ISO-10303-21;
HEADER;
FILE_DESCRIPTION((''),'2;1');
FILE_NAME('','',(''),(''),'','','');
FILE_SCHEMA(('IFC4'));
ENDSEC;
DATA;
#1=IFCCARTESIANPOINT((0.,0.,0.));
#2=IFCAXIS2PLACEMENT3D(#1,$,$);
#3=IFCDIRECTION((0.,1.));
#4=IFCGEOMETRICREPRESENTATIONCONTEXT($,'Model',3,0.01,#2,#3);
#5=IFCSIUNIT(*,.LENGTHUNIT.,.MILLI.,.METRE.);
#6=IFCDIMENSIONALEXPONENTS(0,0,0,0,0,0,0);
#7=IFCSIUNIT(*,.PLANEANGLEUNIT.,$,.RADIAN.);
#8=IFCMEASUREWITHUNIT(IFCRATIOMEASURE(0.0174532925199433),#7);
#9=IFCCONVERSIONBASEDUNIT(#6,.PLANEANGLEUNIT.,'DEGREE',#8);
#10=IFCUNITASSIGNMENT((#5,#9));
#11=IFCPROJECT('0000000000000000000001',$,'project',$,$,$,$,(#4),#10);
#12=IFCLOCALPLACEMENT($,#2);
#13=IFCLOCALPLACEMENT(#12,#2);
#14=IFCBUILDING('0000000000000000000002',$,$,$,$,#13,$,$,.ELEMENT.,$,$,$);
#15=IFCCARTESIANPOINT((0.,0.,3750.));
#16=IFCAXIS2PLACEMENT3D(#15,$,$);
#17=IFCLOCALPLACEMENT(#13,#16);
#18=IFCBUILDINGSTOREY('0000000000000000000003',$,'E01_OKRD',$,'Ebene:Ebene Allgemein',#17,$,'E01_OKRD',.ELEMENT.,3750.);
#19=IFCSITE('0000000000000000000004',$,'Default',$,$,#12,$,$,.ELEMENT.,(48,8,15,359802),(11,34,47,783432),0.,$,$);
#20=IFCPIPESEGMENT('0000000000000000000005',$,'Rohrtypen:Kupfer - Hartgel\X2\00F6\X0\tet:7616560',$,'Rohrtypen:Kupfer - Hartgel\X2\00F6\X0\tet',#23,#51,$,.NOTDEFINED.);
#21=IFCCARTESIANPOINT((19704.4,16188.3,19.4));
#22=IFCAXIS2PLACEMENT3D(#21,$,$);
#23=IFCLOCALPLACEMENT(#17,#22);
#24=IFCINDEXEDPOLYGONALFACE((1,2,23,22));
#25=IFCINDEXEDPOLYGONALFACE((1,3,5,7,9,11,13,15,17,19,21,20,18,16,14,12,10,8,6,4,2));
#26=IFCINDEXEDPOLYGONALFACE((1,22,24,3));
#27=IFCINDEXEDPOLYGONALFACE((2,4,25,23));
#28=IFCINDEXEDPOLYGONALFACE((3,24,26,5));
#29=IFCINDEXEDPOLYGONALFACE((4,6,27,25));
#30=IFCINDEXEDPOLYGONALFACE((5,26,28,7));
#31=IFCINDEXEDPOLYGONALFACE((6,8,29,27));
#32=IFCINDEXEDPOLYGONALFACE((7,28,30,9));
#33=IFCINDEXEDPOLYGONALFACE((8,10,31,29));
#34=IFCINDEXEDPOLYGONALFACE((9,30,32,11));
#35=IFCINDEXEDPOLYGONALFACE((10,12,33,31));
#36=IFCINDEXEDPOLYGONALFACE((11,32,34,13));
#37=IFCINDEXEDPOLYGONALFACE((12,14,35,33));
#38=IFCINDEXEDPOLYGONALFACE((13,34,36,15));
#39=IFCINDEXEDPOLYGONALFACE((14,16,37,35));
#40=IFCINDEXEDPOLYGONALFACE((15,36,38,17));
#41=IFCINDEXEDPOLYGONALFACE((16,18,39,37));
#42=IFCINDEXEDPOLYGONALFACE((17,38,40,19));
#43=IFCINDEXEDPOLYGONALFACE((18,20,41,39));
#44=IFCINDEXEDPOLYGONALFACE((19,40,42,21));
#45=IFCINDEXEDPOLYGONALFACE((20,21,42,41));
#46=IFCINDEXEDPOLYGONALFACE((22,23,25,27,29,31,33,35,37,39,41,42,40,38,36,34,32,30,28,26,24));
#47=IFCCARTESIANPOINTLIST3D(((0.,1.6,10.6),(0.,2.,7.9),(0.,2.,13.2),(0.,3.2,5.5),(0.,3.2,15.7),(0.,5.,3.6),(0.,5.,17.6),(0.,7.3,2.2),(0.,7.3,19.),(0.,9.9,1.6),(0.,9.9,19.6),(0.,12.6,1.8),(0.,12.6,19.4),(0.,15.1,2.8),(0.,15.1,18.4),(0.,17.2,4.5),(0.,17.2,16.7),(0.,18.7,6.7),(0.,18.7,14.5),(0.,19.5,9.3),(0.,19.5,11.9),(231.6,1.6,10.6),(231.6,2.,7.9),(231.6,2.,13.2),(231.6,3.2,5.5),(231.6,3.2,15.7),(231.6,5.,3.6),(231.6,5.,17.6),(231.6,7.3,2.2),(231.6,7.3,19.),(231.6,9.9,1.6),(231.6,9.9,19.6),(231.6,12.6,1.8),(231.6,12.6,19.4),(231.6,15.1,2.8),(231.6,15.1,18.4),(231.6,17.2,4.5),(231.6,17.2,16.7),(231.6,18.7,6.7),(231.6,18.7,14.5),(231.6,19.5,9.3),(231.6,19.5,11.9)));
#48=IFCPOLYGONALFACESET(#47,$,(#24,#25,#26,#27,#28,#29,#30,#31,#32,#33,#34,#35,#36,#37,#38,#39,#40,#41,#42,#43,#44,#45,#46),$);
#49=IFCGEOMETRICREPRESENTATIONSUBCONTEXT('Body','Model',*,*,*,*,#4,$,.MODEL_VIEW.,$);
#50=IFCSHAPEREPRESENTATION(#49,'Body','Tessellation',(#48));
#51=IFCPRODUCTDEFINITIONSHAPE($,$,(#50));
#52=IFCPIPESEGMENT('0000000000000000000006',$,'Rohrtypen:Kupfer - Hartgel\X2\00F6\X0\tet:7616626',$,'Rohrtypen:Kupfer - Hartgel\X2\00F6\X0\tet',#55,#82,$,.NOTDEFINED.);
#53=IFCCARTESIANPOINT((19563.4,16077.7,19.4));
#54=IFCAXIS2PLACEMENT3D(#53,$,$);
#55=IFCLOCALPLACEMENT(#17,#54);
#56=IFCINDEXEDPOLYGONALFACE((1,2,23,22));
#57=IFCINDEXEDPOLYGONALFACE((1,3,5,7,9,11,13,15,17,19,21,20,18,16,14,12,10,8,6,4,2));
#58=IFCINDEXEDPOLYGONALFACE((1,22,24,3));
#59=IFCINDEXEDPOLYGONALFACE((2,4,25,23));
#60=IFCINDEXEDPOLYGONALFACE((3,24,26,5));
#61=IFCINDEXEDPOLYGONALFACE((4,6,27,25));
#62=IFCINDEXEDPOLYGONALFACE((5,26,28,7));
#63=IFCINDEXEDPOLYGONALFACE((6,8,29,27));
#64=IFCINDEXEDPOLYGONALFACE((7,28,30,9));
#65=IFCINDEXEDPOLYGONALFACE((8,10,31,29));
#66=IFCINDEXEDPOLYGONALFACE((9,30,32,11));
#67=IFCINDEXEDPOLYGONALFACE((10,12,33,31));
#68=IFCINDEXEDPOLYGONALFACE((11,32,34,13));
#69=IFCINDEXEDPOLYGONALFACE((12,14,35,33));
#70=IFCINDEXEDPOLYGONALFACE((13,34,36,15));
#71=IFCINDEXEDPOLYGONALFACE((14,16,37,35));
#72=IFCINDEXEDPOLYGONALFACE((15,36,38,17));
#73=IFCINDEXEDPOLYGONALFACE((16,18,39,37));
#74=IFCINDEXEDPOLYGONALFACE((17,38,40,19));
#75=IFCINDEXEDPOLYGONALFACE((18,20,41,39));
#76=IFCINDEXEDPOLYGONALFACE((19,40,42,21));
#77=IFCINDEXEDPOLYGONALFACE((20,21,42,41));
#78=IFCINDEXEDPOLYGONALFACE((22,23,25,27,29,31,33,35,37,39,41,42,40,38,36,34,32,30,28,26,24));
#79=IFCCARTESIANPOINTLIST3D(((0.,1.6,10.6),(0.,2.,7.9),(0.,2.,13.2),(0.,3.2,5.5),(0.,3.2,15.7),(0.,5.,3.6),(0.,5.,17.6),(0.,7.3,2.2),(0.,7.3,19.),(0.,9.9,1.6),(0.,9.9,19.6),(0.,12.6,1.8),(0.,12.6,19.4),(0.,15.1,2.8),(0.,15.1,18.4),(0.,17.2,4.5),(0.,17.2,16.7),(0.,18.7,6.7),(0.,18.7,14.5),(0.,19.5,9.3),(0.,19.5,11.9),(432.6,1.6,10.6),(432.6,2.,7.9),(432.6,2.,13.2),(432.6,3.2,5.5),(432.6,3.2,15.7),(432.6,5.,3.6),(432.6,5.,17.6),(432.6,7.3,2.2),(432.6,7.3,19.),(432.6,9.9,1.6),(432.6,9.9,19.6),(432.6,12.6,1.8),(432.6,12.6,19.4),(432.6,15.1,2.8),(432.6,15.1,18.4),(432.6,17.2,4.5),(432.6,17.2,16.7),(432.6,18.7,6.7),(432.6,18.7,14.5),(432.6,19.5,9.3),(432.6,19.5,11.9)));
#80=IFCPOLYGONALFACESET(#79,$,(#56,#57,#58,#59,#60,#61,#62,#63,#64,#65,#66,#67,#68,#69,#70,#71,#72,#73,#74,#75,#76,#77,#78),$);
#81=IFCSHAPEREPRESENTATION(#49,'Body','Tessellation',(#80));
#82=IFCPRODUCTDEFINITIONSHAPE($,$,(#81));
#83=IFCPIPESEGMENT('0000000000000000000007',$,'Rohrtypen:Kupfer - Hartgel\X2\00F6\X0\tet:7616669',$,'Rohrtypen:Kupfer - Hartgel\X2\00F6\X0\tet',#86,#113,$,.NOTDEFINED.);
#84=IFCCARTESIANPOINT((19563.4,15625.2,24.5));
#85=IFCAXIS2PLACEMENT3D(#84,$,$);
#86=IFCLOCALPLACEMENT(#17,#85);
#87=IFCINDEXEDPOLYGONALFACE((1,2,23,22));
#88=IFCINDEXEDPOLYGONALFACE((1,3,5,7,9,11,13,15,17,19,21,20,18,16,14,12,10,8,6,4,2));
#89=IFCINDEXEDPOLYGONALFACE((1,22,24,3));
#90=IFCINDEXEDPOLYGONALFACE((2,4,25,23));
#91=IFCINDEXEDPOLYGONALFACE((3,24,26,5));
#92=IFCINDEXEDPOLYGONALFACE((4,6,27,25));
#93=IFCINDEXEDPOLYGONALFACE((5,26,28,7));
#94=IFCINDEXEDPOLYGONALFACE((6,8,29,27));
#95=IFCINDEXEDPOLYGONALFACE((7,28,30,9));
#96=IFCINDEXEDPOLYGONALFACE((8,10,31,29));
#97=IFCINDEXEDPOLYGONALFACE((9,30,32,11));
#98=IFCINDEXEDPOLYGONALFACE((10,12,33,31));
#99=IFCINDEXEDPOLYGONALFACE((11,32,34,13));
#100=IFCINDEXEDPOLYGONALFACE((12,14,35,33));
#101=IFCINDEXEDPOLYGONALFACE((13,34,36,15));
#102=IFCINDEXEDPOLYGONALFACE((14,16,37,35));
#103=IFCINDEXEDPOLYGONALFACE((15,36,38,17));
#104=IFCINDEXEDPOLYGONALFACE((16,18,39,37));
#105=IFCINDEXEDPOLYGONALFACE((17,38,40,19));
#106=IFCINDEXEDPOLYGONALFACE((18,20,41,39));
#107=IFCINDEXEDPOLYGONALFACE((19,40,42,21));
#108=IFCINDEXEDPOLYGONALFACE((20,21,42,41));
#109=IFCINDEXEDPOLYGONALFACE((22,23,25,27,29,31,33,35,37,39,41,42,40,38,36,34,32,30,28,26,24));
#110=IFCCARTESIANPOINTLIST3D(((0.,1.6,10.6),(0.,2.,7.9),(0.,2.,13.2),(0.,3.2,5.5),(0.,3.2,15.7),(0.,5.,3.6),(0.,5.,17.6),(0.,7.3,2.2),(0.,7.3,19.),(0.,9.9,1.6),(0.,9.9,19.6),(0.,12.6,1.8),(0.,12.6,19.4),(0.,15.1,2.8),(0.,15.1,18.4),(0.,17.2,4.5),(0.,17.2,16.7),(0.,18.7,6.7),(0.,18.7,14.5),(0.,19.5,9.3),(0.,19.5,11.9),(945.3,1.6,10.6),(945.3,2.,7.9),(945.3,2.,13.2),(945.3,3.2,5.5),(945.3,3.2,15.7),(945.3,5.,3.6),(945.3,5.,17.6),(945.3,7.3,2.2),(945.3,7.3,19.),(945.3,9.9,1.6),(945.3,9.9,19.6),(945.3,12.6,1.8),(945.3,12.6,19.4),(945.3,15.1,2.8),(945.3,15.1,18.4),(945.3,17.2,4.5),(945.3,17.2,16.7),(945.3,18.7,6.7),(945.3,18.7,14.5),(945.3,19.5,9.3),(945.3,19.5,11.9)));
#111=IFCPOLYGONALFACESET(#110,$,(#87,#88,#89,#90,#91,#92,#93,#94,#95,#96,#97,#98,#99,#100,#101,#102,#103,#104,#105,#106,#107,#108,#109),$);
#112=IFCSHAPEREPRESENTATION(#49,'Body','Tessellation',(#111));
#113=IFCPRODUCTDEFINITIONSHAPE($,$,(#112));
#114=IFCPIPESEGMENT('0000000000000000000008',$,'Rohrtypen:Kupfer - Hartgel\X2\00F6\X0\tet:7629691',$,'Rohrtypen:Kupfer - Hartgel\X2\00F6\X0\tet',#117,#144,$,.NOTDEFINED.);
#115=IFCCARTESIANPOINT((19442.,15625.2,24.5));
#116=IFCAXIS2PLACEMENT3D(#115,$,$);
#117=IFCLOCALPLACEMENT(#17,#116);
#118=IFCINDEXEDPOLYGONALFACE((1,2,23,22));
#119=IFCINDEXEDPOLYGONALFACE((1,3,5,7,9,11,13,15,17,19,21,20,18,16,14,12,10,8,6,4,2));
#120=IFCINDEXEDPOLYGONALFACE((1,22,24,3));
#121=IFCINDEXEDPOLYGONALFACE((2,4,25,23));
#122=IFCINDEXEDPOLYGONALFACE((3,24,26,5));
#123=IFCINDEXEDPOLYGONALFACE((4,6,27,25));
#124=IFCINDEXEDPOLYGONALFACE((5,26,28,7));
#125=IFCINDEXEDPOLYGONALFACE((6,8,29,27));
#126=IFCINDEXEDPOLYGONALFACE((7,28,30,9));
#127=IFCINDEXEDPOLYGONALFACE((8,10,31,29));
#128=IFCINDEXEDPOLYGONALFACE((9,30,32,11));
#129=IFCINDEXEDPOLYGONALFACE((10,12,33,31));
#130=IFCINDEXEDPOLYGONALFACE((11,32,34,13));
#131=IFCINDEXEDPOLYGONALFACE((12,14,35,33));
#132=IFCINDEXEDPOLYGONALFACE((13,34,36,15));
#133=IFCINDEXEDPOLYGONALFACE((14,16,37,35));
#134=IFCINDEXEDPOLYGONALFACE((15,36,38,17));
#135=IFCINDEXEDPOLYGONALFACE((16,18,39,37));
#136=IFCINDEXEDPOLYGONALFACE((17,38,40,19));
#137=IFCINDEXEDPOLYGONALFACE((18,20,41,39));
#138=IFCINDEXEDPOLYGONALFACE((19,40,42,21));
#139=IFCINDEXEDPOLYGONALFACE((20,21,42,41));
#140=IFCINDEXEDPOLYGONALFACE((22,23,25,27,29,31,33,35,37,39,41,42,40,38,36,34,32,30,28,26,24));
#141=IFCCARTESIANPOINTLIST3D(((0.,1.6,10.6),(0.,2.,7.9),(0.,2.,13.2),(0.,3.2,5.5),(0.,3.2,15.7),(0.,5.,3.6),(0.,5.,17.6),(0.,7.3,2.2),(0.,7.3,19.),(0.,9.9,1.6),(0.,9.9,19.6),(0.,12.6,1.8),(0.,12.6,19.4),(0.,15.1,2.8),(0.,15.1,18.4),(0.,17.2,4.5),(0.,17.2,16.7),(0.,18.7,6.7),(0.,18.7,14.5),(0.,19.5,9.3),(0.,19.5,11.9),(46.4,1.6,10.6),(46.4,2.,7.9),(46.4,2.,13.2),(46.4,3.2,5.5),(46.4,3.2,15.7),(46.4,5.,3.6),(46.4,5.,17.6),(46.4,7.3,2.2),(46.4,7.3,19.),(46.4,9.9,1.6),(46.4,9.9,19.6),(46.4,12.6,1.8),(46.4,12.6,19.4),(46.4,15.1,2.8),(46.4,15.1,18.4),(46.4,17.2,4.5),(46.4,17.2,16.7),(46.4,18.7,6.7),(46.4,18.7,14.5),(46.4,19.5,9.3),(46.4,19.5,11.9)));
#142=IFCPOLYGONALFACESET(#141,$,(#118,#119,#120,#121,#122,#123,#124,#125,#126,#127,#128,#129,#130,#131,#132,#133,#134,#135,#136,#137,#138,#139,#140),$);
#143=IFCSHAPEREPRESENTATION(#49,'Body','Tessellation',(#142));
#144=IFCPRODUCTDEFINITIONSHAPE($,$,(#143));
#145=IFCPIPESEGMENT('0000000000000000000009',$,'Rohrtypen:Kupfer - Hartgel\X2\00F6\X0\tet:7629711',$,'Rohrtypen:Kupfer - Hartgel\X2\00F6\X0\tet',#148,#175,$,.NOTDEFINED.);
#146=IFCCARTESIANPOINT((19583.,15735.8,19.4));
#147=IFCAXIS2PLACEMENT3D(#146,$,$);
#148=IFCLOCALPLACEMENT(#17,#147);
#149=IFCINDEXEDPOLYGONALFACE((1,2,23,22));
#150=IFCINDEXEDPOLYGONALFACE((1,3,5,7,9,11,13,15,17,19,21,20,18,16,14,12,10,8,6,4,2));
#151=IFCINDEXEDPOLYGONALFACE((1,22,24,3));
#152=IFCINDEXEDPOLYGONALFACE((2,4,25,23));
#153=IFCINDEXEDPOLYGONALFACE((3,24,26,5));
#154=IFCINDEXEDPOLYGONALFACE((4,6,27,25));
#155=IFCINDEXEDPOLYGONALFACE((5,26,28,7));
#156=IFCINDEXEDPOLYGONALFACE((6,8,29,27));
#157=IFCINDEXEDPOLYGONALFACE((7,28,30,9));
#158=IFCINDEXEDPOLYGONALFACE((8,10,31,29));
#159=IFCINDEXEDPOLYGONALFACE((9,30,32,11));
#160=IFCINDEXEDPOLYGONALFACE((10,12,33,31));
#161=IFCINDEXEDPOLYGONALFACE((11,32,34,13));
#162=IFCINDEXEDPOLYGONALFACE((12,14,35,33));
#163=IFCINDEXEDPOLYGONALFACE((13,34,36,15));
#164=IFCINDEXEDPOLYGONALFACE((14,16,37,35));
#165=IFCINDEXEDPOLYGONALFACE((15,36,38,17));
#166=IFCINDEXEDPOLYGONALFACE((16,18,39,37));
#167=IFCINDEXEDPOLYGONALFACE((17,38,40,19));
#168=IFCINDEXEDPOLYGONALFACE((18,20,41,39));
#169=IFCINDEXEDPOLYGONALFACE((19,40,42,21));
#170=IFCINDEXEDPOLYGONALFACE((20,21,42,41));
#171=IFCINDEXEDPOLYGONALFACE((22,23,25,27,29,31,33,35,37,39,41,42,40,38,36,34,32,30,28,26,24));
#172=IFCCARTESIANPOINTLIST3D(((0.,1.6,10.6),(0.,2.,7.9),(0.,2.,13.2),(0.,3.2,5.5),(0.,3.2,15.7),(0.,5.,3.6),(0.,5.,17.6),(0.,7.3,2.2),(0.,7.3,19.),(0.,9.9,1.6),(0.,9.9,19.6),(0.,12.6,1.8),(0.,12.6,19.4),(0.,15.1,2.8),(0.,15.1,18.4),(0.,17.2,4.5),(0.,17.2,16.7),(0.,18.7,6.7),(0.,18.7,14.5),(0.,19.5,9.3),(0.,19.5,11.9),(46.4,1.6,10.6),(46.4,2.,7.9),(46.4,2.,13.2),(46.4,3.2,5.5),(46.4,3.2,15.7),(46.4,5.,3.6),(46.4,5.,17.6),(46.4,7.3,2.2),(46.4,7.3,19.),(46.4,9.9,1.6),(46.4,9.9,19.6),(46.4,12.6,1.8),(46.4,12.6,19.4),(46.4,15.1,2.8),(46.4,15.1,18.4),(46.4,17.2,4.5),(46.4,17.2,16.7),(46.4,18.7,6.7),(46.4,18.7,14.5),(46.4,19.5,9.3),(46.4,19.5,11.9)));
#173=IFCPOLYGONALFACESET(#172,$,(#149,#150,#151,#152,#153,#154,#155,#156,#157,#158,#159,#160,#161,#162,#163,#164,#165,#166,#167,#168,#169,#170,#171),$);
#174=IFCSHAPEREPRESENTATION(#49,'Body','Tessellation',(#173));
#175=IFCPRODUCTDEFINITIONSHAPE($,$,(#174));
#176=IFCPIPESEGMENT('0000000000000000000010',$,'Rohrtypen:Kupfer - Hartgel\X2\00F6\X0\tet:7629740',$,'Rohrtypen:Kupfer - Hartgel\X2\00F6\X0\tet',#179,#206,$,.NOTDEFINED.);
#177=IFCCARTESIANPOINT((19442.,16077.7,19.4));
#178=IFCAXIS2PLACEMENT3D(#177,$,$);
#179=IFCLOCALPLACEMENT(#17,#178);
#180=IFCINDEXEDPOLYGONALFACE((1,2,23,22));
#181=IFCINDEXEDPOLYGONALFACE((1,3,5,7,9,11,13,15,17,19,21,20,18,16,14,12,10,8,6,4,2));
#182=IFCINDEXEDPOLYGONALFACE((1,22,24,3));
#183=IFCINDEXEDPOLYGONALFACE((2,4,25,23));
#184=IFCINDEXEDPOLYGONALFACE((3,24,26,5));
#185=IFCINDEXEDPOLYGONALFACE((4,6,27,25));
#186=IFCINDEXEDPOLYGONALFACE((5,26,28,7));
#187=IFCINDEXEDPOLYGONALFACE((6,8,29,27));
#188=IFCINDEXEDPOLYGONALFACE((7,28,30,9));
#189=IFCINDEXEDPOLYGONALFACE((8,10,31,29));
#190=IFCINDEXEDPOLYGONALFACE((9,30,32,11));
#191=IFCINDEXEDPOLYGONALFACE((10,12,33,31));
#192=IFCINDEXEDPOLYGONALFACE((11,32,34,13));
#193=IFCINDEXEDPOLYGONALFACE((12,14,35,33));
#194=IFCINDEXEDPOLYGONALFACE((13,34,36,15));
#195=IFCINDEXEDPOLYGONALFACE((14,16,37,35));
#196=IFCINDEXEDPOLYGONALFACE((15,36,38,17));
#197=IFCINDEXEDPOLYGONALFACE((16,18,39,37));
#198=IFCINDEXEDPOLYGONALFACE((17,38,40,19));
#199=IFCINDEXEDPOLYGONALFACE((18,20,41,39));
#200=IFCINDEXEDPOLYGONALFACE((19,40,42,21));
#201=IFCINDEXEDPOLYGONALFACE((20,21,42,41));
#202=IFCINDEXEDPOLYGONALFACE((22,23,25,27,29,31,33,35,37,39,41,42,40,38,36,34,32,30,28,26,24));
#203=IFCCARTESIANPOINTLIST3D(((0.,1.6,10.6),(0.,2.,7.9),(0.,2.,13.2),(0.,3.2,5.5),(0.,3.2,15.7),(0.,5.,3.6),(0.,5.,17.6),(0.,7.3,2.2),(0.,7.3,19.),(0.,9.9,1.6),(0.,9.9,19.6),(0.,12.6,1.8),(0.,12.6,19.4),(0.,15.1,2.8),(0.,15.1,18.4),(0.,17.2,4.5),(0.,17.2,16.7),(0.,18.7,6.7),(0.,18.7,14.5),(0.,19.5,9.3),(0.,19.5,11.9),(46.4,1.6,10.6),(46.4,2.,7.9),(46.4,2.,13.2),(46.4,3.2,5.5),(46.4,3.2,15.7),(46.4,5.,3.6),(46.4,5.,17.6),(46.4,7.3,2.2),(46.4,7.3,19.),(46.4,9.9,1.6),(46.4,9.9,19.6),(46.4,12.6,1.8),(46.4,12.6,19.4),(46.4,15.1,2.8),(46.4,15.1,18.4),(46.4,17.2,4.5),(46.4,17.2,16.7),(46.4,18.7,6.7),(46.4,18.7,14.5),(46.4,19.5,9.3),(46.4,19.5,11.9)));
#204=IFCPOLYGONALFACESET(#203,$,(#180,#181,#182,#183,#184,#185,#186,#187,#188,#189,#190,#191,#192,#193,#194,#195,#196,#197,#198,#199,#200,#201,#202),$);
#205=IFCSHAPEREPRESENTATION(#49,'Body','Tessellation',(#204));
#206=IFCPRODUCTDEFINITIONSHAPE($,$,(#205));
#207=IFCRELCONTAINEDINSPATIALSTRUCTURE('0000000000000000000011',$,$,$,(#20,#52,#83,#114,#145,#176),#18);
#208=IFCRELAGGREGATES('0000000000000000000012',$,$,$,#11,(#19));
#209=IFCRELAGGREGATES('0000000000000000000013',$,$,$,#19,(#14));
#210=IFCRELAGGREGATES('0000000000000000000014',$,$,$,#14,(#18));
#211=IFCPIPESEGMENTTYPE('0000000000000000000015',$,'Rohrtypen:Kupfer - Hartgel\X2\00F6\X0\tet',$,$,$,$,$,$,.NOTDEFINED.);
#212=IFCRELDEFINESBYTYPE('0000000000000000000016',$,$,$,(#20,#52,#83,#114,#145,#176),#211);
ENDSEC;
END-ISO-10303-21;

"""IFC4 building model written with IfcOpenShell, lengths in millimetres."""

from ifc_helpers import new_model, entity, si_unit, converted_unit, direction, frame, origin, origin_2d_with_axis, place, context, subcontext, project, spatial, circle, extrude, type_object, element, save


model = new_model("IFC4")

# Units and contexts
model_context = context("Model", 3, precision=0.01, world=origin(), true_north=direction((0.0, 1.0)))
body_context = subcontext(model_context, "Body", "Model", "MODEL_VIEW")
ifc_project = project(units=[si_unit("LENGTHUNIT", "METRE", prefix="MILLI"), converted_unit("PLANEANGLEUNIT", "DEGREE", entity("IfcRatioMeasure", 0.0174532925199433), si_unit("PLANEANGLEUNIT", "RADIAN"), dimensions=[0, 0, 0, 0, 0, 0, 0])], contexts=[model_context])

# Site, building, storey
site_placement = place(None, origin())
site = spatial("IfcSite", under=ifc_project, at=site_placement, Name="Default", CompositionType="ELEMENT", RefLatitude=(48, 8, 15, 359802), RefLongitude=(11, 34, 47, 783432), RefElevation=0.0)
building_placement = place(site_placement, origin())
building = spatial("IfcBuilding", under=site, at=building_placement, CompositionType="ELEMENT")
storey_placement = place(building_placement, frame((0.0, 0.0, 3750.0)))
storey = spatial("IfcBuildingStorey", under=building, at=storey_placement, Name="E01_OKRD", ObjectType="Ebene:Ebene Allgemein", LongName="E01_OKRD", CompositionType="ELEMENT", Elevation=3750.0)

# Pipe segments
pipe_segment_type = type_object("IfcPipeSegmentType", Name="Rohrtypen:Kupfer - Hartgelötet", PredefinedType="NOTDEFINED")
pipe_segment_1_placement = place(storey_placement, frame((19704.4, 16188.3, 19.4)))
element("IfcPipeSegment", 1, at=pipe_segment_1_placement, inside=storey, type_object=pipe_segment_type, Name="Rohrtypen:Kupfer - Hartgelötet:7616560", ObjectType="Rohrtypen:Kupfer - Hartgelötet", PredefinedType="NOTDEFINED", context=body_context, shape_type="SweptSolid", body=[
    extrude(circle(Radius=9.0, at=origin_2d_with_axis()), frame((0.0, 10.6, 10.6), z_axis=(1.0, 0.0, 0.0), x_axis=(0.0, -1.0, 0.0)), (0.0, 0.0, 1.0), 231.6),
])
pipe_segment_2_placement = place(storey_placement, frame((19563.4, 16077.7, 19.4)))
element("IfcPipeSegment", 2, at=pipe_segment_2_placement, inside=storey, type_object=pipe_segment_type, Name="Rohrtypen:Kupfer - Hartgelötet:7616626", ObjectType="Rohrtypen:Kupfer - Hartgelötet", PredefinedType="NOTDEFINED", context=body_context, shape_type="SweptSolid", body=[
    extrude(circle(Radius=9.0, at=origin_2d_with_axis()), frame((0.0, 10.6, 10.6), z_axis=(1.0, 0.0, 0.0), x_axis=(0.0, -1.0, 0.0)), (0.0, 0.0, 1.0), 432.6),
])
pipe_segment_3_placement = place(storey_placement, frame((19563.4, 15625.2, 24.5)))
element("IfcPipeSegment", 3, at=pipe_segment_3_placement, inside=storey, type_object=pipe_segment_type, Name="Rohrtypen:Kupfer - Hartgelötet:7616669", ObjectType="Rohrtypen:Kupfer - Hartgelötet", PredefinedType="NOTDEFINED", context=body_context, shape_type="SweptSolid", body=[
    extrude(circle(Radius=9.0, at=origin_2d_with_axis()), frame((0.0, 10.6, 10.6), z_axis=(1.0, 0.0, 0.0), x_axis=(0.0, -1.0, 0.0)), (0.0, 0.0, 1.0), 945.3),
])
pipe_segment_4_placement = place(storey_placement, frame((19442.0, 15625.2, 24.5)))
element("IfcPipeSegment", 4, at=pipe_segment_4_placement, inside=storey, type_object=pipe_segment_type, Name="Rohrtypen:Kupfer - Hartgelötet:7629691", ObjectType="Rohrtypen:Kupfer - Hartgelötet", PredefinedType="NOTDEFINED", context=body_context, shape_type="SweptSolid", body=[
    extrude(circle(Radius=9.0, at=origin_2d_with_axis()), frame((0.0, 10.6, 10.6), z_axis=(1.0, 0.0, 0.0), x_axis=(0.0, -1.0, 0.0)), (0.0, 0.0, 1.0), 46.4),
])
pipe_segment_5_placement = place(storey_placement, frame((19583.0, 15735.8, 19.4)))
element("IfcPipeSegment", 5, at=pipe_segment_5_placement, inside=storey, type_object=pipe_segment_type, Name="Rohrtypen:Kupfer - Hartgelötet:7629711", ObjectType="Rohrtypen:Kupfer - Hartgelötet", PredefinedType="NOTDEFINED", context=body_context, shape_type="SweptSolid", body=[
    extrude(circle(Radius=9.0, at=origin_2d_with_axis()), frame((0.0, 10.6, 10.6), z_axis=(1.0, 0.0, 0.0), x_axis=(0.0, -1.0, 0.0)), (0.0, 0.0, 1.0), 46.4),
])
pipe_segment_6_placement = place(storey_placement, frame((19442.0, 16077.7, 19.4)))
element("IfcPipeSegment", 6, at=pipe_segment_6_placement, inside=storey, type_object=pipe_segment_type, Name="Rohrtypen:Kupfer - Hartgelötet:7629740", ObjectType="Rohrtypen:Kupfer - Hartgelötet", PredefinedType="NOTDEFINED", context=body_context, shape_type="SweptSolid", body=[
    extrude(circle(Radius=9.0, at=origin_2d_with_axis()), frame((0.0, 10.6, 10.6), z_axis=(1.0, 0.0, 0.0), x_axis=(0.0, -1.0, 0.0)), (0.0, 0.0, 1.0), 46.4),
])

save(model, "model.ifc")
